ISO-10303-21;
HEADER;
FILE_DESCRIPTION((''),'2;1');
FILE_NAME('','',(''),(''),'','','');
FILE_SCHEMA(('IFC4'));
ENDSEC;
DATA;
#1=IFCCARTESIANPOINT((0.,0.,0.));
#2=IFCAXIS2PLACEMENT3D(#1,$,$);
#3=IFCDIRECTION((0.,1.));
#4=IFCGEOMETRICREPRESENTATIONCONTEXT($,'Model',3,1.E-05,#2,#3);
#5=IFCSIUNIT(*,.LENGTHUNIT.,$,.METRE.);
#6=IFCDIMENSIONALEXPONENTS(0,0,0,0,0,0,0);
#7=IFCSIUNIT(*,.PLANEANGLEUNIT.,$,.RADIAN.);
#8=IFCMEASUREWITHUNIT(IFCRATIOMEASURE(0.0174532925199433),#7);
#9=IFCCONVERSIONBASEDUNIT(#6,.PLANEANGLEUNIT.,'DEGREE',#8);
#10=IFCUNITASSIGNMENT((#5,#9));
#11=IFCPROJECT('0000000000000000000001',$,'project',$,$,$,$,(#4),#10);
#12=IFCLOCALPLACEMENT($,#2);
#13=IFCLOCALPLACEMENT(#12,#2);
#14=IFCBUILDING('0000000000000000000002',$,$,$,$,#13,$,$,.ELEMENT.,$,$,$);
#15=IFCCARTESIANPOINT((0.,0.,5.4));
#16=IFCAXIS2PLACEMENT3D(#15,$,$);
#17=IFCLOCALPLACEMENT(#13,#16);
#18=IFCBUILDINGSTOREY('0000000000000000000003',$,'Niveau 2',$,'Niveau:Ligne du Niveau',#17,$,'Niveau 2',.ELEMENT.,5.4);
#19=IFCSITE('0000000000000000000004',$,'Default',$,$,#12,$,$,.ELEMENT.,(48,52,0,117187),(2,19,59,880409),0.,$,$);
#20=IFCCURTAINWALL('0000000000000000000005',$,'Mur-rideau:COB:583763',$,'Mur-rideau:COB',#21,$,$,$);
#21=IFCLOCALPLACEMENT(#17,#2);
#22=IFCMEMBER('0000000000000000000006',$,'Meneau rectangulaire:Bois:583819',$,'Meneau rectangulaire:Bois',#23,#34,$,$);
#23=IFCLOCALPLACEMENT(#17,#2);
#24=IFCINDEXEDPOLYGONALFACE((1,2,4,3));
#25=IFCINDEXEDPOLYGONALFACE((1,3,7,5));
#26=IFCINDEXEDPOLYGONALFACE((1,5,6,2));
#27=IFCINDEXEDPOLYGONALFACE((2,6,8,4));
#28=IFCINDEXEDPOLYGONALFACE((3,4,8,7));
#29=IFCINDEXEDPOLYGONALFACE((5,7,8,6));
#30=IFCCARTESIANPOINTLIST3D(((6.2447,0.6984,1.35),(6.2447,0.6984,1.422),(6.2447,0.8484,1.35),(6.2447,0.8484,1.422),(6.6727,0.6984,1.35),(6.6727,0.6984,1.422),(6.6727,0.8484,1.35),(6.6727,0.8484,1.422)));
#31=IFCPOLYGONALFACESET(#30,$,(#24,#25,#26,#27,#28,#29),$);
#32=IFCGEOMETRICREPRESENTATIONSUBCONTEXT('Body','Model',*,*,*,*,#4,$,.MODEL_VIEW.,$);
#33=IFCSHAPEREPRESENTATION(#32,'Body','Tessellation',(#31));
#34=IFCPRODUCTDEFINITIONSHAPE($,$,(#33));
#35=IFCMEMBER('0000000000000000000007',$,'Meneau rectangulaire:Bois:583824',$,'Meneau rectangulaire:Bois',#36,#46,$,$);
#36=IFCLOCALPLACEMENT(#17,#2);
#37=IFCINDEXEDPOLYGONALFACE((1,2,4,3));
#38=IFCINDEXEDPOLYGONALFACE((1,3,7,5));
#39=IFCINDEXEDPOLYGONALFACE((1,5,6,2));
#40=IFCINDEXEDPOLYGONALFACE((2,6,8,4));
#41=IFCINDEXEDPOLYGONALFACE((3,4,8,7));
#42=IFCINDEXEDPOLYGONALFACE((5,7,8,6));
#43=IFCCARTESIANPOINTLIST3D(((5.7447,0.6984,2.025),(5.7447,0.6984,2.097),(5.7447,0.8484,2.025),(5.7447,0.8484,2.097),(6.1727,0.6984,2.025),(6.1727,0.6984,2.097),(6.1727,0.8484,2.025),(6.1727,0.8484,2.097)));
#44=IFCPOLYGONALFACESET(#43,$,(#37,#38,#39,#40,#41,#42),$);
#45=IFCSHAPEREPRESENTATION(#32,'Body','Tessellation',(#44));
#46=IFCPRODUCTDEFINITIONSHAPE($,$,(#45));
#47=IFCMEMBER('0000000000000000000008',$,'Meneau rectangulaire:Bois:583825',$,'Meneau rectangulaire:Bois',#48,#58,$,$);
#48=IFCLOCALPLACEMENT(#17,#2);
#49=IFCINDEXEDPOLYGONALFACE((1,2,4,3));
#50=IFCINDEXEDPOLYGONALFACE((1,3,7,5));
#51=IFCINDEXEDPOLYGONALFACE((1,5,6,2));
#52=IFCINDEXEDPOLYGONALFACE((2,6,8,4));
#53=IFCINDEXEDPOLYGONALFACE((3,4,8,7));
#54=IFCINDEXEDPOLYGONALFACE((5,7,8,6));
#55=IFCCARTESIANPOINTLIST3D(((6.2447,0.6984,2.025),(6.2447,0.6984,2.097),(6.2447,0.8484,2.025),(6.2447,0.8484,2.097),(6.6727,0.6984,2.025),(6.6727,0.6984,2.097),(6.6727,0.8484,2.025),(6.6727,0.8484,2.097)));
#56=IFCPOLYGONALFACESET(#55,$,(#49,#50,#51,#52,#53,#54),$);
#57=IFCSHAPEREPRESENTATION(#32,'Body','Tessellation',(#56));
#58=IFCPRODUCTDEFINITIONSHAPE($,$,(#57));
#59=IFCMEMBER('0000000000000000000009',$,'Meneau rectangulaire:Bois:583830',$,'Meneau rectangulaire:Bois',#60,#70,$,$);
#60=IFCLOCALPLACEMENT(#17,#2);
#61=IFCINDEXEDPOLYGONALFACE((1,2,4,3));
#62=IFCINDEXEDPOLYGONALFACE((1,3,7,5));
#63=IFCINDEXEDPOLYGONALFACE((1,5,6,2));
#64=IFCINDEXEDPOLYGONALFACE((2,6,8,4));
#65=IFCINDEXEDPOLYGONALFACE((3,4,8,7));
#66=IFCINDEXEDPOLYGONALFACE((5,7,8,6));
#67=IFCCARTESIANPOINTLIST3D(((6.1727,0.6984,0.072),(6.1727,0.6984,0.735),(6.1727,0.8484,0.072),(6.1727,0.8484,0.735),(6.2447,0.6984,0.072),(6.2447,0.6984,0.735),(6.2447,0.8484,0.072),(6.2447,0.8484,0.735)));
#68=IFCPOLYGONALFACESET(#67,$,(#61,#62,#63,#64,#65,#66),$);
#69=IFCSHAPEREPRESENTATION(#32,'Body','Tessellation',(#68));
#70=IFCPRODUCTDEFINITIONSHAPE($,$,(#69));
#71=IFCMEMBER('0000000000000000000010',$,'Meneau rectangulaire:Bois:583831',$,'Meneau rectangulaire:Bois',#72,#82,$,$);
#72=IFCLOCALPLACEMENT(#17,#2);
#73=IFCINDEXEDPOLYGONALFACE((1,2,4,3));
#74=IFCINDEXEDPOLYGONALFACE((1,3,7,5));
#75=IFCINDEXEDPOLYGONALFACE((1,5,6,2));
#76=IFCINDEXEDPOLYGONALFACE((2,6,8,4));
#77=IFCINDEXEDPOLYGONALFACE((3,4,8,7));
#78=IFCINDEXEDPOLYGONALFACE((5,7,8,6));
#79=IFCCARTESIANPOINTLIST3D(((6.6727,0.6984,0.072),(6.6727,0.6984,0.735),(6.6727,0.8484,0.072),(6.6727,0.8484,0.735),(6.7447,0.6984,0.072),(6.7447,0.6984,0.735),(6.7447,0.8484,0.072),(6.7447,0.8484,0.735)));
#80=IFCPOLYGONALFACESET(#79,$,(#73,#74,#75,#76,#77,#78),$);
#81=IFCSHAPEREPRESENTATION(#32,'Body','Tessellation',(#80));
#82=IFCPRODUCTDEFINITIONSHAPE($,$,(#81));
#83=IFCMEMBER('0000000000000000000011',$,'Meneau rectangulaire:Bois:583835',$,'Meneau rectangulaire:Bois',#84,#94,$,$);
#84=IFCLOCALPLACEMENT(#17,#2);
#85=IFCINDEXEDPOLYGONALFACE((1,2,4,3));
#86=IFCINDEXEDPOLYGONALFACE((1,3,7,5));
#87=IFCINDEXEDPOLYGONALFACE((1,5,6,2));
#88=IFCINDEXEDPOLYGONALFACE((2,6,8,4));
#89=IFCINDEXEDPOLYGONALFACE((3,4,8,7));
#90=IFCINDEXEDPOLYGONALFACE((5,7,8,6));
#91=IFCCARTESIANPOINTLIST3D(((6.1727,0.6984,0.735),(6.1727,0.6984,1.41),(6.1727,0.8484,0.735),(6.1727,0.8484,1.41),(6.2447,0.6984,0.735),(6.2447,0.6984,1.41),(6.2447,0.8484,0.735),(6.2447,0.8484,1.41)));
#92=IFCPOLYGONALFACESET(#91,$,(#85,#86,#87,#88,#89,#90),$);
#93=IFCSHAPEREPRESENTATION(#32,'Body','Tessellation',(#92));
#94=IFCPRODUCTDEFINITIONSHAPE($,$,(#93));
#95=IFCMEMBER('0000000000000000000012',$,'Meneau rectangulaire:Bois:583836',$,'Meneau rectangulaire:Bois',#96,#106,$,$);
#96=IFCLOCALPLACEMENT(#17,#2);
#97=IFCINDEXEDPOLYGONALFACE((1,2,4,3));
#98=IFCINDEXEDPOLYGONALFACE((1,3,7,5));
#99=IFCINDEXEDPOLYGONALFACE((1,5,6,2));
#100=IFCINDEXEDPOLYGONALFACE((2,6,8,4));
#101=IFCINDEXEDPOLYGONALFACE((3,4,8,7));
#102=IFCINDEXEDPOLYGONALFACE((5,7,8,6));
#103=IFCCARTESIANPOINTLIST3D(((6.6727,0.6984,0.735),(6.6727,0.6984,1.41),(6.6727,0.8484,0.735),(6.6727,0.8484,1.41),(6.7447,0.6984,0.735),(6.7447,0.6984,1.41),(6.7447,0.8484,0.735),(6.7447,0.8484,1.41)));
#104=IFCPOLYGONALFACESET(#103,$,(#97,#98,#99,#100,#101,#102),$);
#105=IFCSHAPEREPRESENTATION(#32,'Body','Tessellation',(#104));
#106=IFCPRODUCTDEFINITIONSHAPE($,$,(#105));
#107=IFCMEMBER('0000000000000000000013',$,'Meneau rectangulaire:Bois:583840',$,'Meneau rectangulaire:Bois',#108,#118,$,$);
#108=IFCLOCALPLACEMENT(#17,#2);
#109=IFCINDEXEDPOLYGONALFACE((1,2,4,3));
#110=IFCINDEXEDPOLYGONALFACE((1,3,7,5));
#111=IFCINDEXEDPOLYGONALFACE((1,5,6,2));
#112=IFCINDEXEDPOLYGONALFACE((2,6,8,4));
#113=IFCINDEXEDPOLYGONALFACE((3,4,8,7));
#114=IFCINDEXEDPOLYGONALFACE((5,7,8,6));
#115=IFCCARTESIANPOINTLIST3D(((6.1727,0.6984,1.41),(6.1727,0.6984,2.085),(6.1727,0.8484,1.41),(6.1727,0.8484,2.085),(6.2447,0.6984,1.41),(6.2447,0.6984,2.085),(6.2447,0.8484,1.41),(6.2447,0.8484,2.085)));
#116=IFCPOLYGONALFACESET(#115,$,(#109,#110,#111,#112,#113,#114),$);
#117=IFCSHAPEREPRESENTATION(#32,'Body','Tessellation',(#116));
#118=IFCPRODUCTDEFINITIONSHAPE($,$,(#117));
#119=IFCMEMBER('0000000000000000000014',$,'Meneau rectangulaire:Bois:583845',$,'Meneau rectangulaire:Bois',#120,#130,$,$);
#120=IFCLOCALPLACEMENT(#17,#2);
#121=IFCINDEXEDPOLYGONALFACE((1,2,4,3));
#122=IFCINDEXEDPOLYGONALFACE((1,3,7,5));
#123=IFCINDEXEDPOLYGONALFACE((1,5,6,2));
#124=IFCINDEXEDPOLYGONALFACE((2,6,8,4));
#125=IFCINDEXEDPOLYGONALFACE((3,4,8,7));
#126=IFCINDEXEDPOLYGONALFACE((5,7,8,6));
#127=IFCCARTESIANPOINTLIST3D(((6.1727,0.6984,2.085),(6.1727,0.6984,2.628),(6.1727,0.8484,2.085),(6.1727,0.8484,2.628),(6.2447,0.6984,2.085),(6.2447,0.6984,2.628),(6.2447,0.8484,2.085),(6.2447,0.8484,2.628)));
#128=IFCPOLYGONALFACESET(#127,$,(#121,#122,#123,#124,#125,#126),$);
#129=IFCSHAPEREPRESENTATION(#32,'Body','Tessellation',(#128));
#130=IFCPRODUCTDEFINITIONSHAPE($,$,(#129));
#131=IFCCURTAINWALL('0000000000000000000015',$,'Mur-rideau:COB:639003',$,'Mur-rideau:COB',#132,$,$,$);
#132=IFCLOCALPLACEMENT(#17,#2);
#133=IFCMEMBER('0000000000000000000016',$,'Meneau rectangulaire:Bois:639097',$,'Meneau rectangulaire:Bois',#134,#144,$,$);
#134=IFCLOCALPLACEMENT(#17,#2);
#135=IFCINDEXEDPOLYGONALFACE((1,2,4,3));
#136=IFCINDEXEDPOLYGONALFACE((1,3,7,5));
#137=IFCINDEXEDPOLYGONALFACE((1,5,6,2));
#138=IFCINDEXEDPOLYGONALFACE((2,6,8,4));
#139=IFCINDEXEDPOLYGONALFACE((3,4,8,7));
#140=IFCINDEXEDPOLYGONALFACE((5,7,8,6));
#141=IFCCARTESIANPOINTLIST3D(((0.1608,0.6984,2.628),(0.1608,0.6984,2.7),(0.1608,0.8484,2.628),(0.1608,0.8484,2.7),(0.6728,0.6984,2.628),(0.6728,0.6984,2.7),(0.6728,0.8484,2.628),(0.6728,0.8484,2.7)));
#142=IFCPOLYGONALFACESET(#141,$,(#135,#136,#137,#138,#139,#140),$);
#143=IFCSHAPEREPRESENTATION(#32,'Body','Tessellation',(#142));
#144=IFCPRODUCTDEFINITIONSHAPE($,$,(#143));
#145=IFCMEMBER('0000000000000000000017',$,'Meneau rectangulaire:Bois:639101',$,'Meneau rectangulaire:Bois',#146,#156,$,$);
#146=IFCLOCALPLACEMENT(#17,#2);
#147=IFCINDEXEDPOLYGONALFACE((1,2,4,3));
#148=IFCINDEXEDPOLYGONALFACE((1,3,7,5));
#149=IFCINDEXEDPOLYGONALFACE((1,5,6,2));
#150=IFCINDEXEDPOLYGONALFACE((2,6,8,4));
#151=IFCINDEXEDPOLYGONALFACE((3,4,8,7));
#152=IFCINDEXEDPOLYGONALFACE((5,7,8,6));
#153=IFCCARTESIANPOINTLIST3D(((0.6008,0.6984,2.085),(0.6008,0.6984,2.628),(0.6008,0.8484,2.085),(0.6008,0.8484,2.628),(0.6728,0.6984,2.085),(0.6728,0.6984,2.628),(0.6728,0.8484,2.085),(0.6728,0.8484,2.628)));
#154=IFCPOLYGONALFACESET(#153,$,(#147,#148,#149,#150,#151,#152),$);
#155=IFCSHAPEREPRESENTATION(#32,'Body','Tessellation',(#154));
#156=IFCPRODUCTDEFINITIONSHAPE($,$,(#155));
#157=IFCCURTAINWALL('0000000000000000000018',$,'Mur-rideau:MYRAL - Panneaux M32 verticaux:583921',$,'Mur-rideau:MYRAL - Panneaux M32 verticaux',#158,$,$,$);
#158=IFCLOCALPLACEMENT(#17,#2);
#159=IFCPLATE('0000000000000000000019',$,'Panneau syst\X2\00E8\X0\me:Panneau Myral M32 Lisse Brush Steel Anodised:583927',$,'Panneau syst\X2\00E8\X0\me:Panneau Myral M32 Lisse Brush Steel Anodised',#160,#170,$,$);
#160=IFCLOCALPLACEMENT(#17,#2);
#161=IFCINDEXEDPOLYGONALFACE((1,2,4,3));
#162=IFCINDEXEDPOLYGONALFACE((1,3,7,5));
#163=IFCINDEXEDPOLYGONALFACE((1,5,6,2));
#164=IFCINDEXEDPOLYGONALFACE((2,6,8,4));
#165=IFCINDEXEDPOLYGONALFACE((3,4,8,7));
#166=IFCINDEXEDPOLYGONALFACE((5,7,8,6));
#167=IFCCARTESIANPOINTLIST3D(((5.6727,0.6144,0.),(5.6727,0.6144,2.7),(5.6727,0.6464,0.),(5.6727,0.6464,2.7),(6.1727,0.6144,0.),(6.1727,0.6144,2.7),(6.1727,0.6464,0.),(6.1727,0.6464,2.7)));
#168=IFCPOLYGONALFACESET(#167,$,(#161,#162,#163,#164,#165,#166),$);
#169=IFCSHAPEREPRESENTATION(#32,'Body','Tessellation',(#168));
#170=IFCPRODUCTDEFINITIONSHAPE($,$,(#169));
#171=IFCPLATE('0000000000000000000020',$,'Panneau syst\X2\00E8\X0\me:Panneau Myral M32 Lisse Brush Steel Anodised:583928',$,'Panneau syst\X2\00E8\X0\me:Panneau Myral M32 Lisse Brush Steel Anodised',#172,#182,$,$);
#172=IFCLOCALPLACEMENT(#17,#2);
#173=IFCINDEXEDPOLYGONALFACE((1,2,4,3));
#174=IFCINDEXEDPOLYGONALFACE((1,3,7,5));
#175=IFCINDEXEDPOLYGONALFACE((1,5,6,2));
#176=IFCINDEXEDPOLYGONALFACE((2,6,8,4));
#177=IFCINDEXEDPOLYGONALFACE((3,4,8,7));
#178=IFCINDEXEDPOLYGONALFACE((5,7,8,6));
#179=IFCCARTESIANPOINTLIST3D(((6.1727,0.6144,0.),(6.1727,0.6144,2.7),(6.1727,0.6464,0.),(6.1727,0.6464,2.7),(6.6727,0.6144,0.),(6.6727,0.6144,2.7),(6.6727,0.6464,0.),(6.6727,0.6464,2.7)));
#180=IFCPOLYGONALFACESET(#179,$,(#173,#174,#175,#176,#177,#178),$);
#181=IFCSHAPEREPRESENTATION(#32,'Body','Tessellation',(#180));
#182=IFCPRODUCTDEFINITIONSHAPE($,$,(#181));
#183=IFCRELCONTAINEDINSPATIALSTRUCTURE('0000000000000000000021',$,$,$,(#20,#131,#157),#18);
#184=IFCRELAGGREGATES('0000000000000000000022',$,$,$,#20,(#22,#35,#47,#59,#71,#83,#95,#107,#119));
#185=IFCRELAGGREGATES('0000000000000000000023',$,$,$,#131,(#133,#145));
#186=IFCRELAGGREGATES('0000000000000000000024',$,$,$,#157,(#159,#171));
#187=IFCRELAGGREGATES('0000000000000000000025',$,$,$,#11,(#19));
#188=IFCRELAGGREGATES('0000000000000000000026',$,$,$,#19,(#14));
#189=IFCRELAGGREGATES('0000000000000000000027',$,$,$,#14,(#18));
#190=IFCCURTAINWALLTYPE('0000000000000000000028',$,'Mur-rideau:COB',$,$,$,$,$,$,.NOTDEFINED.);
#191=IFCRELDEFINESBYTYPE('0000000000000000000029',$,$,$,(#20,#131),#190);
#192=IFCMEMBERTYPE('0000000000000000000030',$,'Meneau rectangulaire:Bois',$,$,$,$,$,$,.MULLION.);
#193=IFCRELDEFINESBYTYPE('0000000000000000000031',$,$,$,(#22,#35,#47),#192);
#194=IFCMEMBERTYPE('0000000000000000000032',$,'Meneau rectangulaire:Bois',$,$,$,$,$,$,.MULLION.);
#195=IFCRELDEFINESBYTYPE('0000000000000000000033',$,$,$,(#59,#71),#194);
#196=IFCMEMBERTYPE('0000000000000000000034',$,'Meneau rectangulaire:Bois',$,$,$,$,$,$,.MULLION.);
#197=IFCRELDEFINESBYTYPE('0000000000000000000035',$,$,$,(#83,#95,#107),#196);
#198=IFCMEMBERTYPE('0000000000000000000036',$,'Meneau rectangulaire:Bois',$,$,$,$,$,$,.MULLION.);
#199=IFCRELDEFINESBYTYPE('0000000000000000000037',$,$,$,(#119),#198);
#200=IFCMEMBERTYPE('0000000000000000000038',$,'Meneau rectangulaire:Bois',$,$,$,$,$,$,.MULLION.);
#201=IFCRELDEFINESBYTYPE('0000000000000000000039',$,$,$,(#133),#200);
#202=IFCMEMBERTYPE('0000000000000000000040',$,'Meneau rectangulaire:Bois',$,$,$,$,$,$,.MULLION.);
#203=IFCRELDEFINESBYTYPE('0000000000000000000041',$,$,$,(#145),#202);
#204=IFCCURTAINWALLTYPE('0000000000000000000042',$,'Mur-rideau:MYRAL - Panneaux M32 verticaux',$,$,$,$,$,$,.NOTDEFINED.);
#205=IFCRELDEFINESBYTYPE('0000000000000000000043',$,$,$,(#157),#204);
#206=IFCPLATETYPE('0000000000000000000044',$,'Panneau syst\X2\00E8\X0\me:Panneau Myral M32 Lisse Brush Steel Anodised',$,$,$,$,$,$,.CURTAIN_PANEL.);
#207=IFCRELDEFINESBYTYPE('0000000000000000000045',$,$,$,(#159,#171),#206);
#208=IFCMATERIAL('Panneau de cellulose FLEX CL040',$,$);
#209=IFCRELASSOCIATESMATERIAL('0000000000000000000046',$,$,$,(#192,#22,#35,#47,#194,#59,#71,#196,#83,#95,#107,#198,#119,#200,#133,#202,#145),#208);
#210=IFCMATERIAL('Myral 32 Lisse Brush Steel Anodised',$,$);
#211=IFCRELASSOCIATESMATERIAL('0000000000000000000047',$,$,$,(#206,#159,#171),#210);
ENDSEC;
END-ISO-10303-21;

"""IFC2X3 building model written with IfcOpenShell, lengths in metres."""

from ifc_helpers import new_model, entity, si_unit, converted_unit, direction, frame, origin, origin_2d_with_axis, place, context, subcontext, project, spatial, rectangle, extrude, source, transform, mapped, material, type_object, type_shapes, element, aggregate, save


model = new_model("IFC2X3")

# Units and contexts
model_context = context("Model", 3, precision=1e-05, world=origin(), true_north=direction((0.0, 1.0)))
body_context = subcontext(model_context, "Body", "Model", "MODEL_VIEW")
ifc_project = project(units=[si_unit("LENGTHUNIT", "METRE"), converted_unit("PLANEANGLEUNIT", "DEGREE", entity("IfcRatioMeasure", 0.0174532925199433), si_unit("PLANEANGLEUNIT", "RADIAN"), dimensions=[0, 0, 0, 0, 0, 0, 0])], contexts=[model_context])

# Site, building, storey
site_placement = place(None, origin())
site = spatial("IfcSite", under=ifc_project, at=site_placement, Name="Default", CompositionType="ELEMENT", RefLatitude=(48, 52, 0, 117187), RefLongitude=(2, 19, 59, 880409), RefElevation=0.0)
building_placement = place(site_placement, origin())
building = spatial("IfcBuilding", under=site, at=building_placement, CompositionType="ELEMENT")
storey_placement = place(building_placement, frame((0.0, 0.0, 5.4)))
storey = spatial("IfcBuildingStorey", under=building, at=storey_placement, Name="Niveau 2", ObjectType="Niveau:Ligne du Niveau", LongName="Niveau 2", CompositionType="ELEMENT", Elevation=5.4)

# Curtain walls, members
curtain_wall_type_1 = type_object("IfcCurtainWallType", Name="Mur-rideau:COB", PredefinedType="NOTDEFINED")
curtain_wall_1_placement = place(storey_placement, frame((0.0, 0.0, -5.4)))
curtain_wall_1 = element("IfcCurtainWall", 1, at=curtain_wall_1_placement, inside=storey, type_object=curtain_wall_type_1, Name="Mur-rideau:COB:583763", ObjectType="Mur-rideau:COB")
ifc_material_1 = material(Name="Panneau de cellulose FLEX CL040")
member_type_1 = type_object("IfcMemberType", Name="Meneau rectangulaire:Bois", PredefinedType="MULLION", material=ifc_material_1)
shared_shape_1 = source(origin(), body_context, "Body", "SweptSolid", [
    extrude(rectangle(XDim=0.15, YDim=0.072, at=origin_2d_with_axis()), frame((-0.024, 0.0, -0.428), z_axis=(0.0, 0.0, 1.0), x_axis=(0.0, -1.0, 0.0)), (0.0, 0.0, 1.0), 0.428),
])
type_shapes(member_type_1, [shared_shape_1])
member_1_placement = place(storey_placement, frame((6.6727, 0.7734, 1.41), z_axis=(1.0, 0.0, 0.0), x_axis=(0.0, 0.0, 1.0)))
member_1 = element("IfcMember", 2, at=member_1_placement, type_object=member_type_1, material=ifc_material_1, Name="Meneau rectangulaire:Bois:583819", ObjectType="Meneau rectangulaire:Bois", context=body_context, shape_type="MappedRepresentation", body=[
    mapped(shared_shape_1, transform((0.0, 0.0, 0.0), scale=1.0)),
])
member_2_placement = place(storey_placement, frame((6.1727, 0.7734, 2.085), z_axis=(1.0, 0.0, 0.0), x_axis=(0.0, 0.0, 1.0)))
member_2 = element("IfcMember", 3, at=member_2_placement, type_object=member_type_1, material=ifc_material_1, Name="Meneau rectangulaire:Bois:583824", ObjectType="Meneau rectangulaire:Bois", context=body_context, shape_type="MappedRepresentation", body=[
    mapped(shared_shape_1, transform((0.0, 0.0, 0.0), scale=1.0)),
])
member_3_placement = place(storey_placement, frame((6.6727, 0.7734, 2.085), z_axis=(1.0, 0.0, 0.0), x_axis=(0.0, 0.0, 1.0)))
member_3 = element("IfcMember", 4, at=member_3_placement, type_object=member_type_1, material=ifc_material_1, Name="Meneau rectangulaire:Bois:583825", ObjectType="Meneau rectangulaire:Bois", context=body_context, shape_type="MappedRepresentation", body=[
    mapped(shared_shape_1, transform((0.0, 0.0, 0.0), scale=1.0)),
])
member_type_2 = type_object("IfcMemberType", Name="Meneau rectangulaire:Bois", PredefinedType="MULLION", material=ifc_material_1)
shared_shape_2 = source(origin(), body_context, "Body", "SweptSolid", [
    extrude(rectangle(XDim=0.15, YDim=0.072, at=origin_2d_with_axis()), frame((-0.024, 0.0, -0.663), z_axis=(0.0, 0.0, 1.0), x_axis=(0.0, -1.0, 0.0)), (0.0, 0.0, 1.0), 0.663),
])
type_shapes(member_type_2, [shared_shape_2])
member_4_placement = place(storey_placement, frame((6.2327, 0.7734, 0.072), z_axis=(0.0, 0.0, -1.0), x_axis=(1.0, 0.0, 0.0)))
member_4 = element("IfcMember", 5, at=member_4_placement, type_object=member_type_2, material=ifc_material_1, Name="Meneau rectangulaire:Bois:583830", ObjectType="Meneau rectangulaire:Bois", context=body_context, shape_type="MappedRepresentation", body=[
    mapped(shared_shape_2, transform((0.0, 0.0, 0.0), scale=1.0)),
])
member_5_placement = place(storey_placement, frame((6.7327, 0.7734, 0.072), z_axis=(0.0, 0.0, -1.0), x_axis=(1.0, 0.0, 0.0)))
member_5 = element("IfcMember", 6, at=member_5_placement, type_object=member_type_2, material=ifc_material_1, Name="Meneau rectangulaire:Bois:583831", ObjectType="Meneau rectangulaire:Bois", context=body_context, shape_type="MappedRepresentation", body=[
    mapped(shared_shape_2, transform((0.0, 0.0, 0.0), scale=1.0)),
])
member_type_3 = type_object("IfcMemberType", Name="Meneau rectangulaire:Bois", PredefinedType="MULLION", material=ifc_material_1)
shared_shape_3 = source(origin(), body_context, "Body", "SweptSolid", [
    extrude(rectangle(XDim=0.15, YDim=0.072, at=origin_2d_with_axis()), frame((-0.024, 0.0, -0.675), z_axis=(0.0, 0.0, 1.0), x_axis=(0.0, -1.0, 0.0)), (0.0, 0.0, 1.0), 0.675),
])
type_shapes(member_type_3, [shared_shape_3])
member_6_placement = place(storey_placement, frame((6.2327, 0.7734, 0.735), z_axis=(0.0, 0.0, -1.0), x_axis=(1.0, 0.0, 0.0)))
member_6 = element("IfcMember", 7, at=member_6_placement, type_object=member_type_3, material=ifc_material_1, Name="Meneau rectangulaire:Bois:583835", ObjectType="Meneau rectangulaire:Bois", context=body_context, shape_type="MappedRepresentation", body=[
    mapped(shared_shape_3, transform((0.0, 0.0, 0.0), scale=1.0)),
])
member_7_placement = place(storey_placement, frame((6.7327, 0.7734, 0.735), z_axis=(0.0, 0.0, -1.0), x_axis=(1.0, 0.0, 0.0)))
member_7 = element("IfcMember", 8, at=member_7_placement, type_object=member_type_3, material=ifc_material_1, Name="Meneau rectangulaire:Bois:583836", ObjectType="Meneau rectangulaire:Bois", context=body_context, shape_type="MappedRepresentation", body=[
    mapped(shared_shape_3, transform((0.0, 0.0, 0.0), scale=1.0)),
])
member_8_placement = place(storey_placement, frame((6.2327, 0.7734, 1.41), z_axis=(0.0, 0.0, -1.0), x_axis=(1.0, 0.0, 0.0)))
member_8 = element("IfcMember", 9, at=member_8_placement, type_object=member_type_3, material=ifc_material_1, Name="Meneau rectangulaire:Bois:583840", ObjectType="Meneau rectangulaire:Bois", context=body_context, shape_type="MappedRepresentation", body=[
    mapped(shared_shape_3, transform((0.0, 0.0, 0.0), scale=1.0)),
])
member_type_4 = type_object("IfcMemberType", Name="Meneau rectangulaire:Bois", PredefinedType="MULLION", material=ifc_material_1)
shared_shape_4 = source(origin(), body_context, "Body", "SweptSolid", [
    extrude(rectangle(XDim=0.15, YDim=0.072, at=origin_2d_with_axis()), frame((-0.024, 0.0, -0.543), z_axis=(0.0, 0.0, 1.0), x_axis=(0.0, -1.0, 0.0)), (0.0, 0.0, 1.0), 0.543),
])
type_shapes(member_type_4, [shared_shape_4])
member_9_placement = place(storey_placement, frame((6.2327, 0.7734, 2.085), z_axis=(0.0, 0.0, -1.0), x_axis=(1.0, 0.0, 0.0)))
member_9 = element("IfcMember", 10, at=member_9_placement, type_object=member_type_4, material=ifc_material_1, Name="Meneau rectangulaire:Bois:583845", ObjectType="Meneau rectangulaire:Bois", context=body_context, shape_type="MappedRepresentation", body=[
    mapped(shared_shape_4, transform((0.0, 0.0, 0.0), scale=1.0)),
])
aggregate(curtain_wall_1, [member_1, member_2, member_3, member_4, member_5, member_6, member_7, member_8, member_9])
curtain_wall_2_placement = place(storey_placement, frame((0.0, 0.0, -5.4)))
curtain_wall_2 = element("IfcCurtainWall", 11, at=curtain_wall_2_placement, inside=storey, type_object=curtain_wall_type_1, Name="Mur-rideau:COB:639003", ObjectType="Mur-rideau:COB")
member_type_5 = type_object("IfcMemberType", Name="Meneau rectangulaire:Bois", PredefinedType="MULLION", material=ifc_material_1)
shared_shape_5 = source(origin(), body_context, "Body", "SweptSolid", [
    extrude(rectangle(XDim=0.15, YDim=0.072, at=origin_2d_with_axis()), frame((-0.036, 0.0, -0.512), z_axis=(0.0, 0.0, 1.0), x_axis=(0.0, -1.0, 0.0)), (0.0, 0.0, 1.0), 0.512),
])
type_shapes(member_type_5, [shared_shape_5])
member_10_placement = place(storey_placement, frame((0.6728, 0.7734, 2.7), z_axis=(1.0, 0.0, 0.0), x_axis=(0.0, 0.0, 1.0)))
member_10 = element("IfcMember", 12, at=member_10_placement, type_object=member_type_5, material=ifc_material_1, Name="Meneau rectangulaire:Bois:639097", ObjectType="Meneau rectangulaire:Bois", context=body_context, shape_type="MappedRepresentation", body=[
    mapped(shared_shape_5, transform((0.0, 0.0, 0.0), scale=1.0)),
])
member_type_6 = type_object("IfcMemberType", Name="Meneau rectangulaire:Bois", PredefinedType="MULLION", material=ifc_material_1)
shared_shape_6 = source(origin(), body_context, "Body", "SweptSolid", [
    extrude(rectangle(XDim=0.15, YDim=0.072, at=origin_2d_with_axis()), frame((-0.024, 0.0, -0.543), z_axis=(0.0, 0.0, 1.0), x_axis=(0.0, -1.0, 0.0)), (0.0, 0.0, 1.0), 0.543),
])
type_shapes(member_type_6, [shared_shape_6])
member_11_placement = place(storey_placement, frame((0.6608, 0.7734, 2.085), z_axis=(0.0, 0.0, -1.0), x_axis=(1.0, 0.0, 0.0)))
member_11 = element("IfcMember", 13, at=member_11_placement, type_object=member_type_6, material=ifc_material_1, Name="Meneau rectangulaire:Bois:639101", ObjectType="Meneau rectangulaire:Bois", context=body_context, shape_type="MappedRepresentation", body=[
    mapped(shared_shape_6, transform((0.0, 0.0, 0.0), scale=1.0)),
])
aggregate(curtain_wall_2, [member_10, member_11])

# Curtain wall, plates
curtain_wall_type_2 = type_object("IfcCurtainWallType", Name="Mur-rideau:MYRAL - Panneaux M32 verticaux", PredefinedType="NOTDEFINED")
curtain_wall_3_placement = place(storey_placement, frame((0.0, 0.0, -5.4)))
curtain_wall_3 = element("IfcCurtainWall", 14, at=curtain_wall_3_placement, inside=storey, type_object=curtain_wall_type_2, Name="Mur-rideau:MYRAL - Panneaux M32 verticaux:583921", ObjectType="Mur-rideau:MYRAL - Panneaux M32 verticaux")
ifc_material_2 = material(Name="Myral 32 Lisse Brush Steel Anodised")
plate_type = type_object("IfcPlateType", Name="Panneau système:Panneau Myral M32 Lisse Brush Steel Anodised", PredefinedType="CURTAIN_PANEL", material=ifc_material_2)
shared_shape_7 = source(origin(), body_context, "Body", "SweptSolid", [
    extrude(rectangle(XDim=0.032, YDim=0.5, at=origin_2d_with_axis()), frame((0.0, -0.016, 0.0), z_axis=(0.0, 0.0, 1.0), x_axis=(0.0, 1.0, 0.0)), (0.0, 0.0, 1.0), 2.7),
])
type_shapes(plate_type, [shared_shape_7])
plate_1_placement = place(curtain_wall_3_placement, frame((5.9227, 0.6464, 5.4)))
plate_1 = element("IfcPlate", 15, at=plate_1_placement, type_object=plate_type, material=ifc_material_2, Name="Panneau système:Panneau Myral M32 Lisse Brush Steel Anodised:583927", ObjectType="Panneau système:Panneau Myral M32 Lisse Brush Steel Anodised", context=body_context, shape_type="MappedRepresentation", body=[
    mapped(shared_shape_7, transform((0.0, 0.0, 0.0), scale=1.0)),
])
plate_2_placement = place(curtain_wall_3_placement, frame((6.4227, 0.6464, 5.4)))
plate_2 = element("IfcPlate", 16, at=plate_2_placement, type_object=plate_type, material=ifc_material_2, Name="Panneau système:Panneau Myral M32 Lisse Brush Steel Anodised:583928", ObjectType="Panneau système:Panneau Myral M32 Lisse Brush Steel Anodised", context=body_context, shape_type="MappedRepresentation", body=[
    mapped(shared_shape_7, transform((0.0, 0.0, 0.0), scale=1.0)),
])
aggregate(curtain_wall_3, [plate_1, plate_2])

save(model, "model.ifc")
